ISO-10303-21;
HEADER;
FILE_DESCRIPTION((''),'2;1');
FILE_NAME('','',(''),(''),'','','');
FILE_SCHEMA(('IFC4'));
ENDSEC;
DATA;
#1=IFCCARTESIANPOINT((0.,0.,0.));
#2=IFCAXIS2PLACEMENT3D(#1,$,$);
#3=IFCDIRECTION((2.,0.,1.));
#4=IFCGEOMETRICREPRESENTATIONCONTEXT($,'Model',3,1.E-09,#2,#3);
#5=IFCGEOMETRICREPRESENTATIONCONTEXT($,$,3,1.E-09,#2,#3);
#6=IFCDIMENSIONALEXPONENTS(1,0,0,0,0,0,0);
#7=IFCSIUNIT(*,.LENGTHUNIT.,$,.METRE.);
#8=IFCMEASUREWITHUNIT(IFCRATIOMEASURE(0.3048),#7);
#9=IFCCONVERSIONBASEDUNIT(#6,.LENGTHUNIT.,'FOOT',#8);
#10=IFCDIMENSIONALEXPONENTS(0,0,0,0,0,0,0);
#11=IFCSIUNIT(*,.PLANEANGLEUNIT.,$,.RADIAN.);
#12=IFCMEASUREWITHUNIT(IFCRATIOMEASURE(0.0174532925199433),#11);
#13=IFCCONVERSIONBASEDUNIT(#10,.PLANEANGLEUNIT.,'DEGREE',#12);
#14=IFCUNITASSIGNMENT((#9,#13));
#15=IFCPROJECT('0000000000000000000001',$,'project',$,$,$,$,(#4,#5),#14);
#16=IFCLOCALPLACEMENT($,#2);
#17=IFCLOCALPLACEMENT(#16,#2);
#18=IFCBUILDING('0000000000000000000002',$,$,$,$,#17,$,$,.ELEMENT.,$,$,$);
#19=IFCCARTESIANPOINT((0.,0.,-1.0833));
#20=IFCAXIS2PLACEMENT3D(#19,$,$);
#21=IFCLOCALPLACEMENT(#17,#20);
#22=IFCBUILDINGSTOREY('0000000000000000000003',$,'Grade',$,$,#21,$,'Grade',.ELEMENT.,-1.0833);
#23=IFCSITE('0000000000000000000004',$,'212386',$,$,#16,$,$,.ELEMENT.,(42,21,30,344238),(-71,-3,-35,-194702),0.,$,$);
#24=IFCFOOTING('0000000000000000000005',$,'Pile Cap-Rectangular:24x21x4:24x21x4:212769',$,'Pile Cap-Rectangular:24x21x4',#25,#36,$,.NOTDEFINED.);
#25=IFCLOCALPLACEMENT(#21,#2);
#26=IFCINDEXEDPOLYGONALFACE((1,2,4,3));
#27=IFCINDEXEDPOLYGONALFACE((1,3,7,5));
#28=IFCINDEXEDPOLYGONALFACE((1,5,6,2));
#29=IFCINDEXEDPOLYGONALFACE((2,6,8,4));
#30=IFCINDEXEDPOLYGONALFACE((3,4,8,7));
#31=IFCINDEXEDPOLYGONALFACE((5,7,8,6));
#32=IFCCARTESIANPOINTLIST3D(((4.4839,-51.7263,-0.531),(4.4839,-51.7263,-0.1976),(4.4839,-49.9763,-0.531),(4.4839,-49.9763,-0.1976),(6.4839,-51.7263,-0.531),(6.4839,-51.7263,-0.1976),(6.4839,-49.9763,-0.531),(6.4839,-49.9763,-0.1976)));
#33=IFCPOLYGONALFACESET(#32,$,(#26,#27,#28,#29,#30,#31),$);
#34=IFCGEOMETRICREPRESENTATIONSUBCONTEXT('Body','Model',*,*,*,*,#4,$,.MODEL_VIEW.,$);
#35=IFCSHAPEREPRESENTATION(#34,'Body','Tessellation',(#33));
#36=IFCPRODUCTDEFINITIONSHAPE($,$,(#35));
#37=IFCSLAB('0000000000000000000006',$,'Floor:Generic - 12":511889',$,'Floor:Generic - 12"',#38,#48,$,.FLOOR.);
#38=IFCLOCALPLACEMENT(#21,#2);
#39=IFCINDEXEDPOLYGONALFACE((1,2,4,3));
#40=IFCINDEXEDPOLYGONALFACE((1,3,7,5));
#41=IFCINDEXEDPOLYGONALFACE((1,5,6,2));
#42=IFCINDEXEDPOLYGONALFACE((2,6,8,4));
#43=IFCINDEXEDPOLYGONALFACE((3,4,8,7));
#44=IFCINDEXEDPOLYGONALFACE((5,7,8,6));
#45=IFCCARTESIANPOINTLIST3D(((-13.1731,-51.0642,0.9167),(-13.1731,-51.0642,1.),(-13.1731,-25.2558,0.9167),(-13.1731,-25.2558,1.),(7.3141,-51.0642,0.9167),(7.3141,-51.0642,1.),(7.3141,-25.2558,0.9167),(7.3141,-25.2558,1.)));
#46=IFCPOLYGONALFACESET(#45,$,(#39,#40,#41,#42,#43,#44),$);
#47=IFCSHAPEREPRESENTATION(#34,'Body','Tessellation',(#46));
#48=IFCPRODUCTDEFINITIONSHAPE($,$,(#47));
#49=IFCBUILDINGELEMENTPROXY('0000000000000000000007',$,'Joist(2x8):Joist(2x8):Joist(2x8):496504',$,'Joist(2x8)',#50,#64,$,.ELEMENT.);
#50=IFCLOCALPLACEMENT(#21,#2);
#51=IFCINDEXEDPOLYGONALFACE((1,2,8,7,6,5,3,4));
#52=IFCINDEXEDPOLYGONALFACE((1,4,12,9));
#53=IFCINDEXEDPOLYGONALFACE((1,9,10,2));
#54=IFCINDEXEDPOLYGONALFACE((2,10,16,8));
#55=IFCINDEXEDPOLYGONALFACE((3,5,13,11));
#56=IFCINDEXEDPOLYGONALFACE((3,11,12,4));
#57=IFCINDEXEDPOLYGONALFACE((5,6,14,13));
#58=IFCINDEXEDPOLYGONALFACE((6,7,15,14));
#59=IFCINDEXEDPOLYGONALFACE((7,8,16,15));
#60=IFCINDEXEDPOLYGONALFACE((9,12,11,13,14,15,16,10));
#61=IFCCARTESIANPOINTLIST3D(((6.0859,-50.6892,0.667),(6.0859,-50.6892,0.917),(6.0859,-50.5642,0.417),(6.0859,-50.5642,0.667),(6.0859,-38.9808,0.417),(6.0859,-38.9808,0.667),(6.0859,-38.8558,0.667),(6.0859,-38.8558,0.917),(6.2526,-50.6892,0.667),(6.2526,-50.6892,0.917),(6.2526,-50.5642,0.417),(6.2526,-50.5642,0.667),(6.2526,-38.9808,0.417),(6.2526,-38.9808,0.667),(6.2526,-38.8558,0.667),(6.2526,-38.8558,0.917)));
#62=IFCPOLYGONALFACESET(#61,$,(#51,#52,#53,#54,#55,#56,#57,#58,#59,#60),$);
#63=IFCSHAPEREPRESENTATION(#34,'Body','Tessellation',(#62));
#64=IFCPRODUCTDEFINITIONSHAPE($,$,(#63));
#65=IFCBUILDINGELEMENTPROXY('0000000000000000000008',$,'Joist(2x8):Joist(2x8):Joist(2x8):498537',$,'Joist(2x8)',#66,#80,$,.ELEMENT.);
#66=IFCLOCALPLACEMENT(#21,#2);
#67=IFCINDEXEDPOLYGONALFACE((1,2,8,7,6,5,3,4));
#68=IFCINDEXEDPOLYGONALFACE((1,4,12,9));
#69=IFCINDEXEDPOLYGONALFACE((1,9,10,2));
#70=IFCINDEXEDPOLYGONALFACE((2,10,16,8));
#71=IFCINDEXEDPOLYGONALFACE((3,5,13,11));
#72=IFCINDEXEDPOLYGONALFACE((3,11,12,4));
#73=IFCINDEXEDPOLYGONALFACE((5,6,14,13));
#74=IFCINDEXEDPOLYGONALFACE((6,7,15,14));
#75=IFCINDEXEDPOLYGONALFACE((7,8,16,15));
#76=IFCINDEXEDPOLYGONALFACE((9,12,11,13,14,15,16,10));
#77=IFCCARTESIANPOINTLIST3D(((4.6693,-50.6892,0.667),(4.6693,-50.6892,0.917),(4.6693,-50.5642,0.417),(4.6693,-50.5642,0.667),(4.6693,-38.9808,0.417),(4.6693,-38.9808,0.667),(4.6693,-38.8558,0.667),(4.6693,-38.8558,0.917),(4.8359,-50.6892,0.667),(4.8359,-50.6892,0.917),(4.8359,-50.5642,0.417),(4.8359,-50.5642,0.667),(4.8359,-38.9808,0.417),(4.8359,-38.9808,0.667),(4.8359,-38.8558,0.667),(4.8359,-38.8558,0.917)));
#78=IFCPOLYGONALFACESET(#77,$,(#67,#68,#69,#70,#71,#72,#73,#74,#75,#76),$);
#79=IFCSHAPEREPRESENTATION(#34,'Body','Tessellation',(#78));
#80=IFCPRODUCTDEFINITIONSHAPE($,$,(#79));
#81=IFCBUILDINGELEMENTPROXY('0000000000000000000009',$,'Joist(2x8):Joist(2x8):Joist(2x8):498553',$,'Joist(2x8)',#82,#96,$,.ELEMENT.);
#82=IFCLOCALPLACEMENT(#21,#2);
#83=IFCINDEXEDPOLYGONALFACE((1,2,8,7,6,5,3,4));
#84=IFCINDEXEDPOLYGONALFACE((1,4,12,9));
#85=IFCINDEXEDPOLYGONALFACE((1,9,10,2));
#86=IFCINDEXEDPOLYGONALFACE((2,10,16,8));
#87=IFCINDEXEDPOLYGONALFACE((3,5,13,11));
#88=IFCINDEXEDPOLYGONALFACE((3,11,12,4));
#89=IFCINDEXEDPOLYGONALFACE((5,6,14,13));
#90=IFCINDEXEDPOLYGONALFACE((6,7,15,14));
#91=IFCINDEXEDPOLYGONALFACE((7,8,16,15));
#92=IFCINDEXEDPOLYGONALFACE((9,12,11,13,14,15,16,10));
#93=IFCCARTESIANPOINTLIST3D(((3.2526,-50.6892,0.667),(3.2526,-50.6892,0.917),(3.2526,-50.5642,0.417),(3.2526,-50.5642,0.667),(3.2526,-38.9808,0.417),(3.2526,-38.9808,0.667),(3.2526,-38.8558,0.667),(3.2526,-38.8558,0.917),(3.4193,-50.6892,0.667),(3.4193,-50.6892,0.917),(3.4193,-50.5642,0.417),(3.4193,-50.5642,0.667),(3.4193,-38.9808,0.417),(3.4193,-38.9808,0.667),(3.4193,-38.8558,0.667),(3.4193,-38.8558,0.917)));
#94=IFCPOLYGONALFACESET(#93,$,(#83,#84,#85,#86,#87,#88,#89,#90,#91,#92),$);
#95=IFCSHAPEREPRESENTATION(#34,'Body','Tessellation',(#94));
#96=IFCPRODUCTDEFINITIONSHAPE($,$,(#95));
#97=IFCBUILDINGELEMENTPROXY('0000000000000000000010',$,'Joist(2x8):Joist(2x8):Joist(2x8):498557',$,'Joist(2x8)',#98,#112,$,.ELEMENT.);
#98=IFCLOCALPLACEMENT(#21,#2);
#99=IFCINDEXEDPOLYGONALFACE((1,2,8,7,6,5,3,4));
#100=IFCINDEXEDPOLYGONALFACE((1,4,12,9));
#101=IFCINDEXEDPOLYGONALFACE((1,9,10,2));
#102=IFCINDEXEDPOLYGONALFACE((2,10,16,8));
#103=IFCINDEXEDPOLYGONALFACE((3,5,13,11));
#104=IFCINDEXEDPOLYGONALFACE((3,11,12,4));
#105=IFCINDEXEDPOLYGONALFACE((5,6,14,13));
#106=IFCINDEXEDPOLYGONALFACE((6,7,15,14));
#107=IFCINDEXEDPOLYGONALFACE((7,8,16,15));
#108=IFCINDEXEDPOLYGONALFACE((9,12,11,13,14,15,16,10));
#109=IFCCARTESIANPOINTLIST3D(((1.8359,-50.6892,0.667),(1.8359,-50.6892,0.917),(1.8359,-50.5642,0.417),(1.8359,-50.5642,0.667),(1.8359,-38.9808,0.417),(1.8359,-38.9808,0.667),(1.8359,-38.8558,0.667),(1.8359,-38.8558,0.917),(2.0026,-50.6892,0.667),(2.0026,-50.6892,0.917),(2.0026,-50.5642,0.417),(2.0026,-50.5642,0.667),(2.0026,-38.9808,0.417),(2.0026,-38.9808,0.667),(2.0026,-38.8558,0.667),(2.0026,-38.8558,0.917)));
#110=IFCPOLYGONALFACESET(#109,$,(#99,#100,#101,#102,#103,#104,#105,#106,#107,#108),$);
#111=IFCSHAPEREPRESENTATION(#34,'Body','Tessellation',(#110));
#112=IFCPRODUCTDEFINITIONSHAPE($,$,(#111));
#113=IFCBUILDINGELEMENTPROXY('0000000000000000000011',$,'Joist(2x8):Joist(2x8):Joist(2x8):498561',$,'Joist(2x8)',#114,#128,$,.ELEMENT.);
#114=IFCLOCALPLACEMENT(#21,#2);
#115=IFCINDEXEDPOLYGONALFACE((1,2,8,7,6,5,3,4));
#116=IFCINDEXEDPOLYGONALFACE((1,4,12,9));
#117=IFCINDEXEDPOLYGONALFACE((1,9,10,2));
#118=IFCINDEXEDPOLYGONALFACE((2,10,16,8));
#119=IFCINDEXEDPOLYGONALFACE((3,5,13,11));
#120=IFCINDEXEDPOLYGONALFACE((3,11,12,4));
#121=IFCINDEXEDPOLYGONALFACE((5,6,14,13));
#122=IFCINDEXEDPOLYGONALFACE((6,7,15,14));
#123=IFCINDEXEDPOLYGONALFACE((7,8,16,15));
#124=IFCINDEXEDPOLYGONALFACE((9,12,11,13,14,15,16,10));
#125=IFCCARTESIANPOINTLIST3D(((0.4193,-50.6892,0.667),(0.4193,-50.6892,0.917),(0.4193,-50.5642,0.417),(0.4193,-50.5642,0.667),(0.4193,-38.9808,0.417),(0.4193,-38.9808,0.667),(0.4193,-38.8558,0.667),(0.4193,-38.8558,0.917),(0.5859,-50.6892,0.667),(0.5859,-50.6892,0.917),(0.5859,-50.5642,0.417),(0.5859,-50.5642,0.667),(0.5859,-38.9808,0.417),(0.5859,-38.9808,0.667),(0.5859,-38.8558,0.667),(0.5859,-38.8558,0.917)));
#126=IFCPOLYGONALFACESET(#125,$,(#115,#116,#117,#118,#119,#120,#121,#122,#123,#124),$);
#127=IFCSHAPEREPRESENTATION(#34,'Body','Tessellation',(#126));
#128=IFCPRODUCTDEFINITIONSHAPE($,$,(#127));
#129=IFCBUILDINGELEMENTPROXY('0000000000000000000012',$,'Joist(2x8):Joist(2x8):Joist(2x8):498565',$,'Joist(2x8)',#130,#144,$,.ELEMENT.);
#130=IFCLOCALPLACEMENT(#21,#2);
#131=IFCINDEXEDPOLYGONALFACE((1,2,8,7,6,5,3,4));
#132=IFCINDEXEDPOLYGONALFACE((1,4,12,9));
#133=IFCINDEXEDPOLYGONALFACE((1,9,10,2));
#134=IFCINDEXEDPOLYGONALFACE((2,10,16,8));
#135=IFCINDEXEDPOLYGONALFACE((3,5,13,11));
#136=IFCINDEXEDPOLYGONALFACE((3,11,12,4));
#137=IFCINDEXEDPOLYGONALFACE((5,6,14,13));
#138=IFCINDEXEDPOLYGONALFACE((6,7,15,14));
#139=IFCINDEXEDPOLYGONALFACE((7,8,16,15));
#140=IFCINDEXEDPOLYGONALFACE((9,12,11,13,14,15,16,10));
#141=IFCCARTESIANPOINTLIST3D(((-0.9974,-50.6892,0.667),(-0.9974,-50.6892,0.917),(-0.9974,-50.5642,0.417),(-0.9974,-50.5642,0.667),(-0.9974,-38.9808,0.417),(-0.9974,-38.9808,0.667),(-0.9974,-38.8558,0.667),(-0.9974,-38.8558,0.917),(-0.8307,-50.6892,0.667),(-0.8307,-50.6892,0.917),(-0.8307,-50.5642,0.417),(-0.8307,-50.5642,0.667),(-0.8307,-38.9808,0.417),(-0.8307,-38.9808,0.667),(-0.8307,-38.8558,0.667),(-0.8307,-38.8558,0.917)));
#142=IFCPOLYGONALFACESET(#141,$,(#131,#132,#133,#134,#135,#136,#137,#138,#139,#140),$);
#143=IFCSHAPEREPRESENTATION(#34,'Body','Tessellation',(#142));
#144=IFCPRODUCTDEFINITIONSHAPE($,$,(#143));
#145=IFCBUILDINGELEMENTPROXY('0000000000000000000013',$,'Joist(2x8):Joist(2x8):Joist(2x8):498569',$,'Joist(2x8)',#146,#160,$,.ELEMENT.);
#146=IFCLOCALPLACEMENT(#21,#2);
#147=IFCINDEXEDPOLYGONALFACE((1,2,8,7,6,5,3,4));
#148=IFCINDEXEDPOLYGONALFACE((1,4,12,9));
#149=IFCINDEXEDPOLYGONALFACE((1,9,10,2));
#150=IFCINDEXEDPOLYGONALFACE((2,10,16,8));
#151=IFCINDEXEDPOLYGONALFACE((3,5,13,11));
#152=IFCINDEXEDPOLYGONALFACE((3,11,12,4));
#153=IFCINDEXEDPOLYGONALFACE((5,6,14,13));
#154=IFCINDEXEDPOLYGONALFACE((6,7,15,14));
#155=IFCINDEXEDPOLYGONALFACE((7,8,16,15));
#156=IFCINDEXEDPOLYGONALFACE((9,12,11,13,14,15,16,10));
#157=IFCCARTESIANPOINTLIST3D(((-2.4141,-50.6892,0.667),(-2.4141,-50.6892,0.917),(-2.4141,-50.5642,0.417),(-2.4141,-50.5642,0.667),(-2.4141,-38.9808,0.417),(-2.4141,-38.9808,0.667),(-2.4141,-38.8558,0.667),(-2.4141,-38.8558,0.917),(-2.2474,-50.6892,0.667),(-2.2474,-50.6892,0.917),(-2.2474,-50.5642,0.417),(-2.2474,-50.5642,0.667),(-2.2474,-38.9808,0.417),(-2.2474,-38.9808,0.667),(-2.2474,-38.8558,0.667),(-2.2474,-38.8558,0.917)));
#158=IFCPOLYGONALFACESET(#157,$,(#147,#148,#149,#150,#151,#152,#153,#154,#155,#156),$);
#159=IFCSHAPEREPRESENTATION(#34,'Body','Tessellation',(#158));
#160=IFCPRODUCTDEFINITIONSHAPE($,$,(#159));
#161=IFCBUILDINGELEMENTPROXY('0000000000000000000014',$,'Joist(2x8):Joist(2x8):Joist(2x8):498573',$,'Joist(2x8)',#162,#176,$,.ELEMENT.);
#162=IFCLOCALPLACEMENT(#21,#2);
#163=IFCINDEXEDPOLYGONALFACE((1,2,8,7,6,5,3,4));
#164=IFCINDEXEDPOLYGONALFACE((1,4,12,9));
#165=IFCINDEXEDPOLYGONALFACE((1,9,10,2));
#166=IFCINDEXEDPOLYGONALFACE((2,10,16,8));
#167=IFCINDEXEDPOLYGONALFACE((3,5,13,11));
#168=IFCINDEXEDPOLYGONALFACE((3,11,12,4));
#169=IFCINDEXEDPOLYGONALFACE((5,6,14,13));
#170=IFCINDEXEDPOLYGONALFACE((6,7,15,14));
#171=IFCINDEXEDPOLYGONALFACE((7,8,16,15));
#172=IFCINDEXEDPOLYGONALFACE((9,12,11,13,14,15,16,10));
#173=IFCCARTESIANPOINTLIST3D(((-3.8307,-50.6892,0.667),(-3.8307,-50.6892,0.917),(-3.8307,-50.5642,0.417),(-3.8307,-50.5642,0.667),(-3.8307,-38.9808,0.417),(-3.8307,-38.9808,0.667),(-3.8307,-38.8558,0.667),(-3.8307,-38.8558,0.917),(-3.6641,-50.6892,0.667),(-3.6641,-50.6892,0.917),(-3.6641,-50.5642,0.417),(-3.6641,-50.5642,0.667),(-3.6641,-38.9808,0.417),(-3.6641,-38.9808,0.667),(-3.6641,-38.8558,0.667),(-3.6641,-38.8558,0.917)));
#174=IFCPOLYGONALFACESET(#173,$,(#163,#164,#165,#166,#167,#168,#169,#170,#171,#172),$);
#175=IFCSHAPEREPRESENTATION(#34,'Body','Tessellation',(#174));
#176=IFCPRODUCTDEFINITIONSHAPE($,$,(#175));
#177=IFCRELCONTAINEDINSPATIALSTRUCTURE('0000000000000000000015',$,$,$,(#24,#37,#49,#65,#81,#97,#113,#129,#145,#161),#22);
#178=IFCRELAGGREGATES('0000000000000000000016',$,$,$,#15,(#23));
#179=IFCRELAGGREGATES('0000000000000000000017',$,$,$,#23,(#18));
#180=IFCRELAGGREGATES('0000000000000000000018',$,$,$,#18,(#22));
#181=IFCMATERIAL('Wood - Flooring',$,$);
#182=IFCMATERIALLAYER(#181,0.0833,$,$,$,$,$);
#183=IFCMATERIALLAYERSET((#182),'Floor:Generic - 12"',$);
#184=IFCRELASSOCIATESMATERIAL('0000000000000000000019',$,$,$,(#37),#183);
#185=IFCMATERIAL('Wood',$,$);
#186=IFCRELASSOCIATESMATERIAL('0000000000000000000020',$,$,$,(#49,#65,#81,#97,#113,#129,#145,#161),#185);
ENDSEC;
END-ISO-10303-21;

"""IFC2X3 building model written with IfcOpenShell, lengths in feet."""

from ifc_helpers import new_model, entity, si_unit, converted_unit, direction, frame, frame_2d, origin, origin_2d_with_axis, place, context, subcontext, project, spatial, polyline, rectangle, outline, extrude, source, transform, mapped, material, layer, layer_set, layer_usage, element, save


model = new_model("IFC2X3")

# Units and contexts
model_context = context("Model", 3, precision=1e-09, world=origin(), true_north=direction((2.0, 0.0, 1.0)))
context_of_model = context(None, 3, precision=1e-09, world=origin(), true_north=direction((2.0, 0.0, 1.0)))
body_context = subcontext(model_context, "Body", "Model", "MODEL_VIEW")
ifc_project = project(units=[converted_unit("LENGTHUNIT", "FOOT", entity("IfcRatioMeasure", 0.3048), si_unit("LENGTHUNIT", "METRE"), dimensions=[1, 0, 0, 0, 0, 0, 0]), converted_unit("PLANEANGLEUNIT", "DEGREE", entity("IfcRatioMeasure", 0.0174532925199433), si_unit("PLANEANGLEUNIT", "RADIAN"), dimensions=[0, 0, 0, 0, 0, 0, 0])], contexts=[model_context, context_of_model])

# Site, building, storey
site_placement = place(None, origin())
site = spatial("IfcSite", under=ifc_project, at=site_placement, Name="212386", CompositionType="ELEMENT", RefLatitude=(42, 21, 30, 344238), RefLongitude=(-71, -3, -35, -194702), RefElevation=0.0)
building_placement = place(site_placement, origin())
building = spatial("IfcBuilding", under=site, at=building_placement, CompositionType="ELEMENT")
storey_placement = place(building_placement, frame((0.0, 0.0, -1.0833)))
storey = spatial("IfcBuildingStorey", under=building, at=storey_placement, Name="Grade", LongName="Grade", CompositionType="ELEMENT", Elevation=-1.0833)

# Footing
footing_placement = place(storey_placement, origin())
element("IfcFooting", 1, at=footing_placement, inside=storey, Name="Pile Cap-Rectangular:24x21x4:24x21x4:212769", ObjectType="Pile Cap-Rectangular:24x21x4", PredefinedType="NOTDEFINED", context=body_context, shape_type="SweptSolid", body=[
    extrude(rectangle(XDim=2.0, YDim=1.75, at=origin_2d_with_axis()), frame((5.4839, -50.8513, -0.531), z_axis=(0.0, 0.0, 1.0), x_axis=(-1.0, 0.0, 0.0)), (0.0, 0.0, 1.0), 0.3333),
])

# Slab
ifc_material_1 = material(Name="Wood - Flooring")
ifc_layer = layer(ifc_material_1, 0.0833)
ifc_layer_set = layer_set([ifc_layer], Name="Floor:Generic - 12\"")
ifc_layer_usage = layer_usage(ifc_layer_set, "AXIS3", "POSITIVE", 0.0)
slab_placement = place(storey_placement, frame((-13.1731, -51.0642, 0.9167)))
element("IfcSlab", 2, at=slab_placement, inside=storey, material=ifc_layer_usage, Name="Floor:Generic - 12\":511889", ObjectType="Floor:Generic - 12\"", PredefinedType="FLOOR", context=body_context, shape_type="SweptSolid", body=[
    extrude(rectangle(XDim=25.8084, YDim=20.4872, at=frame_2d((0.0, 0.0), x_axis=(0.0, -1.0))), frame((10.2436, 12.9042, 0.0833), z_axis=(0.0, 0.0, -1.0), x_axis=(-1.0, 0.0, 0.0)), (0.0, 0.0, 1.0), 0.0833),
])

# Building element proxies
ifc_material_2 = material(Name="Wood")
shared_shape_1 = source(origin(), body_context, "Body", "SweptSolid", [
    extrude(outline(polyline([(-0.25, -5.9167), (0.0, -5.9167), (0.0, -5.7917), (0.25, -5.7917), (0.25, 5.7917), (0.0, 5.7917), (0.0, 5.9167), (-0.25, 5.9167), (-0.25, -5.9167)])), frame((6.0859, -44.7725, -0.4164), z_axis=(1.0, 0.0, 0.0), x_axis=(0.0, 0.0, -1.0)), (0.0, 0.0, 1.0), 0.1667),
])
proxy_1_placement = place(storey_placement, frame((0.0, 0.0, 1.0833)))
element("IfcBuildingElementProxy", 3, at=proxy_1_placement, inside=storey, material=ifc_material_2, Name="Joist(2x8):Joist(2x8):Joist(2x8):496504", ObjectType="Joist(2x8)", CompositionType="ELEMENT", context=body_context, shape_type="MappedRepresentation", body=[
    mapped(shared_shape_1, transform((0.0, 0.0, 0.0), scale=1.0)),
])
shared_shape_2 = source(origin(), body_context, "Body", "SweptSolid", [
    extrude(outline(polyline([(-0.25, -5.9167), (0.0, -5.9167), (0.0, -5.7917), (0.25, -5.7917), (0.25, 5.7917), (0.0, 5.7917), (0.0, 5.9167), (-0.25, 5.9167), (-0.25, -5.9167)])), frame((4.6693, -44.7725, -0.4164), z_axis=(1.0, 0.0, 0.0), x_axis=(0.0, 0.0, -1.0)), (0.0, 0.0, 1.0), 0.1667),
])
proxy_2_placement = place(storey_placement, frame((0.0, 0.0, 1.0833)))
element("IfcBuildingElementProxy", 4, at=proxy_2_placement, inside=storey, material=ifc_material_2, Name="Joist(2x8):Joist(2x8):Joist(2x8):498537", ObjectType="Joist(2x8)", CompositionType="ELEMENT", context=body_context, shape_type="MappedRepresentation", body=[
    mapped(shared_shape_2, transform((0.0, 0.0, 0.0), scale=1.0)),
])
shared_shape_3 = source(origin(), body_context, "Body", "SweptSolid", [
    extrude(outline(polyline([(-0.25, -5.9167), (0.0, -5.9167), (0.0, -5.7917), (0.25, -5.7917), (0.25, 5.7917), (0.0, 5.7917), (0.0, 5.9167), (-0.25, 5.9167), (-0.25, -5.9167)])), frame((3.2526, -44.7725, -0.4164), z_axis=(1.0, 0.0, 0.0), x_axis=(0.0, 0.0, -1.0)), (0.0, 0.0, 1.0), 0.1667),
])
proxy_3_placement = place(storey_placement, frame((0.0, 0.0, 1.0833)))
element("IfcBuildingElementProxy", 5, at=proxy_3_placement, inside=storey, material=ifc_material_2, Name="Joist(2x8):Joist(2x8):Joist(2x8):498553", ObjectType="Joist(2x8)", CompositionType="ELEMENT", context=body_context, shape_type="MappedRepresentation", body=[
    mapped(shared_shape_3, transform((0.0, 0.0, 0.0), scale=1.0)),
])
shared_shape_4 = source(origin(), body_context, "Body", "SweptSolid", [
    extrude(outline(polyline([(-0.25, -5.9167), (0.0, -5.9167), (0.0, -5.7917), (0.25, -5.7917), (0.25, 5.7917), (0.0, 5.7917), (0.0, 5.9167), (-0.25, 5.9167), (-0.25, -5.9167)])), frame((1.8359, -44.7725, -0.4164), z_axis=(1.0, 0.0, 0.0), x_axis=(0.0, 0.0, -1.0)), (0.0, 0.0, 1.0), 0.1667),
])
proxy_4_placement = place(storey_placement, frame((0.0, 0.0, 1.0833)))
element("IfcBuildingElementProxy", 6, at=proxy_4_placement, inside=storey, material=ifc_material_2, Name="Joist(2x8):Joist(2x8):Joist(2x8):498557", ObjectType="Joist(2x8)", CompositionType="ELEMENT", context=body_context, shape_type="MappedRepresentation", body=[
    mapped(shared_shape_4, transform((0.0, 0.0, 0.0), scale=1.0)),
])
shared_shape_5 = source(origin(), body_context, "Body", "SweptSolid", [
    extrude(outline(polyline([(-0.25, -5.9167), (0.0, -5.9167), (0.0, -5.7917), (0.25, -5.7917), (0.25, 5.7917), (0.0, 5.7917), (0.0, 5.9167), (-0.25, 5.9167), (-0.25, -5.9167)])), frame((0.4193, -44.7725, -0.4164), z_axis=(1.0, 0.0, 0.0), x_axis=(0.0, 0.0, -1.0)), (0.0, 0.0, 1.0), 0.1667),
])
proxy_5_placement = place(storey_placement, frame((0.0, 0.0, 1.0833)))
element("IfcBuildingElementProxy", 7, at=proxy_5_placement, inside=storey, material=ifc_material_2, Name="Joist(2x8):Joist(2x8):Joist(2x8):498561", ObjectType="Joist(2x8)", CompositionType="ELEMENT", context=body_context, shape_type="MappedRepresentation", body=[
    mapped(shared_shape_5, transform((0.0, 0.0, 0.0), scale=1.0)),
])
shared_shape_6 = source(origin(), body_context, "Body", "SweptSolid", [
    extrude(outline(polyline([(-0.25, -5.9167), (0.0, -5.9167), (0.0, -5.7917), (0.25, -5.7917), (0.25, 5.7917), (0.0, 5.7917), (0.0, 5.9167), (-0.25, 5.9167), (-0.25, -5.9167)])), frame((-0.9974, -44.7725, -0.4164), z_axis=(1.0, 0.0, 0.0), x_axis=(0.0, 0.0, -1.0)), (0.0, 0.0, 1.0), 0.1667),
])
proxy_6_placement = place(storey_placement, frame((0.0, 0.0, 1.0833)))
element("IfcBuildingElementProxy", 8, at=proxy_6_placement, inside=storey, material=ifc_material_2, Name="Joist(2x8):Joist(2x8):Joist(2x8):498565", ObjectType="Joist(2x8)", CompositionType="ELEMENT", context=body_context, shape_type="MappedRepresentation", body=[
    mapped(shared_shape_6, transform((0.0, 0.0, 0.0), scale=1.0)),
])
shared_shape_7 = source(origin(), body_context, "Body", "SweptSolid", [
    extrude(outline(polyline([(-0.25, -5.9167), (0.0, -5.9167), (0.0, -5.7917), (0.25, -5.7917), (0.25, 5.7917), (0.0, 5.7917), (0.0, 5.9167), (-0.25, 5.9167), (-0.25, -5.9167)])), frame((-2.4141, -44.7725, -0.4164), z_axis=(1.0, 0.0, 0.0), x_axis=(0.0, 0.0, -1.0)), (0.0, 0.0, 1.0), 0.1667),
])
proxy_7_placement = place(storey_placement, frame((0.0, 0.0, 1.0833)))
element("IfcBuildingElementProxy", 9, at=proxy_7_placement, inside=storey, material=ifc_material_2, Name="Joist(2x8):Joist(2x8):Joist(2x8):498569", ObjectType="Joist(2x8)", CompositionType="ELEMENT", context=body_context, shape_type="MappedRepresentation", body=[
    mapped(shared_shape_7, transform((0.0, 0.0, 0.0), scale=1.0)),
])
shared_shape_8 = source(origin(), body_context, "Body", "SweptSolid", [
    extrude(outline(polyline([(-0.25, -5.9167), (0.0, -5.9167), (0.0, -5.7917), (0.25, -5.7917), (0.25, 5.7917), (0.0, 5.7917), (0.0, 5.9167), (-0.25, 5.9167), (-0.25, -5.9167)])), frame((-3.8307, -44.7725, -0.4164), z_axis=(1.0, 0.0, 0.0), x_axis=(0.0, 0.0, -1.0)), (0.0, 0.0, 1.0), 0.1667),
])
proxy_8_placement = place(storey_placement, frame((0.0, 0.0, 1.0833)))
element("IfcBuildingElementProxy", 10, at=proxy_8_placement, inside=storey, material=ifc_material_2, Name="Joist(2x8):Joist(2x8):Joist(2x8):498573", ObjectType="Joist(2x8)", CompositionType="ELEMENT", context=body_context, shape_type="MappedRepresentation", body=[
    mapped(shared_shape_8, transform((0.0, 0.0, 0.0), scale=1.0)),
])

save(model, "model.ifc")
